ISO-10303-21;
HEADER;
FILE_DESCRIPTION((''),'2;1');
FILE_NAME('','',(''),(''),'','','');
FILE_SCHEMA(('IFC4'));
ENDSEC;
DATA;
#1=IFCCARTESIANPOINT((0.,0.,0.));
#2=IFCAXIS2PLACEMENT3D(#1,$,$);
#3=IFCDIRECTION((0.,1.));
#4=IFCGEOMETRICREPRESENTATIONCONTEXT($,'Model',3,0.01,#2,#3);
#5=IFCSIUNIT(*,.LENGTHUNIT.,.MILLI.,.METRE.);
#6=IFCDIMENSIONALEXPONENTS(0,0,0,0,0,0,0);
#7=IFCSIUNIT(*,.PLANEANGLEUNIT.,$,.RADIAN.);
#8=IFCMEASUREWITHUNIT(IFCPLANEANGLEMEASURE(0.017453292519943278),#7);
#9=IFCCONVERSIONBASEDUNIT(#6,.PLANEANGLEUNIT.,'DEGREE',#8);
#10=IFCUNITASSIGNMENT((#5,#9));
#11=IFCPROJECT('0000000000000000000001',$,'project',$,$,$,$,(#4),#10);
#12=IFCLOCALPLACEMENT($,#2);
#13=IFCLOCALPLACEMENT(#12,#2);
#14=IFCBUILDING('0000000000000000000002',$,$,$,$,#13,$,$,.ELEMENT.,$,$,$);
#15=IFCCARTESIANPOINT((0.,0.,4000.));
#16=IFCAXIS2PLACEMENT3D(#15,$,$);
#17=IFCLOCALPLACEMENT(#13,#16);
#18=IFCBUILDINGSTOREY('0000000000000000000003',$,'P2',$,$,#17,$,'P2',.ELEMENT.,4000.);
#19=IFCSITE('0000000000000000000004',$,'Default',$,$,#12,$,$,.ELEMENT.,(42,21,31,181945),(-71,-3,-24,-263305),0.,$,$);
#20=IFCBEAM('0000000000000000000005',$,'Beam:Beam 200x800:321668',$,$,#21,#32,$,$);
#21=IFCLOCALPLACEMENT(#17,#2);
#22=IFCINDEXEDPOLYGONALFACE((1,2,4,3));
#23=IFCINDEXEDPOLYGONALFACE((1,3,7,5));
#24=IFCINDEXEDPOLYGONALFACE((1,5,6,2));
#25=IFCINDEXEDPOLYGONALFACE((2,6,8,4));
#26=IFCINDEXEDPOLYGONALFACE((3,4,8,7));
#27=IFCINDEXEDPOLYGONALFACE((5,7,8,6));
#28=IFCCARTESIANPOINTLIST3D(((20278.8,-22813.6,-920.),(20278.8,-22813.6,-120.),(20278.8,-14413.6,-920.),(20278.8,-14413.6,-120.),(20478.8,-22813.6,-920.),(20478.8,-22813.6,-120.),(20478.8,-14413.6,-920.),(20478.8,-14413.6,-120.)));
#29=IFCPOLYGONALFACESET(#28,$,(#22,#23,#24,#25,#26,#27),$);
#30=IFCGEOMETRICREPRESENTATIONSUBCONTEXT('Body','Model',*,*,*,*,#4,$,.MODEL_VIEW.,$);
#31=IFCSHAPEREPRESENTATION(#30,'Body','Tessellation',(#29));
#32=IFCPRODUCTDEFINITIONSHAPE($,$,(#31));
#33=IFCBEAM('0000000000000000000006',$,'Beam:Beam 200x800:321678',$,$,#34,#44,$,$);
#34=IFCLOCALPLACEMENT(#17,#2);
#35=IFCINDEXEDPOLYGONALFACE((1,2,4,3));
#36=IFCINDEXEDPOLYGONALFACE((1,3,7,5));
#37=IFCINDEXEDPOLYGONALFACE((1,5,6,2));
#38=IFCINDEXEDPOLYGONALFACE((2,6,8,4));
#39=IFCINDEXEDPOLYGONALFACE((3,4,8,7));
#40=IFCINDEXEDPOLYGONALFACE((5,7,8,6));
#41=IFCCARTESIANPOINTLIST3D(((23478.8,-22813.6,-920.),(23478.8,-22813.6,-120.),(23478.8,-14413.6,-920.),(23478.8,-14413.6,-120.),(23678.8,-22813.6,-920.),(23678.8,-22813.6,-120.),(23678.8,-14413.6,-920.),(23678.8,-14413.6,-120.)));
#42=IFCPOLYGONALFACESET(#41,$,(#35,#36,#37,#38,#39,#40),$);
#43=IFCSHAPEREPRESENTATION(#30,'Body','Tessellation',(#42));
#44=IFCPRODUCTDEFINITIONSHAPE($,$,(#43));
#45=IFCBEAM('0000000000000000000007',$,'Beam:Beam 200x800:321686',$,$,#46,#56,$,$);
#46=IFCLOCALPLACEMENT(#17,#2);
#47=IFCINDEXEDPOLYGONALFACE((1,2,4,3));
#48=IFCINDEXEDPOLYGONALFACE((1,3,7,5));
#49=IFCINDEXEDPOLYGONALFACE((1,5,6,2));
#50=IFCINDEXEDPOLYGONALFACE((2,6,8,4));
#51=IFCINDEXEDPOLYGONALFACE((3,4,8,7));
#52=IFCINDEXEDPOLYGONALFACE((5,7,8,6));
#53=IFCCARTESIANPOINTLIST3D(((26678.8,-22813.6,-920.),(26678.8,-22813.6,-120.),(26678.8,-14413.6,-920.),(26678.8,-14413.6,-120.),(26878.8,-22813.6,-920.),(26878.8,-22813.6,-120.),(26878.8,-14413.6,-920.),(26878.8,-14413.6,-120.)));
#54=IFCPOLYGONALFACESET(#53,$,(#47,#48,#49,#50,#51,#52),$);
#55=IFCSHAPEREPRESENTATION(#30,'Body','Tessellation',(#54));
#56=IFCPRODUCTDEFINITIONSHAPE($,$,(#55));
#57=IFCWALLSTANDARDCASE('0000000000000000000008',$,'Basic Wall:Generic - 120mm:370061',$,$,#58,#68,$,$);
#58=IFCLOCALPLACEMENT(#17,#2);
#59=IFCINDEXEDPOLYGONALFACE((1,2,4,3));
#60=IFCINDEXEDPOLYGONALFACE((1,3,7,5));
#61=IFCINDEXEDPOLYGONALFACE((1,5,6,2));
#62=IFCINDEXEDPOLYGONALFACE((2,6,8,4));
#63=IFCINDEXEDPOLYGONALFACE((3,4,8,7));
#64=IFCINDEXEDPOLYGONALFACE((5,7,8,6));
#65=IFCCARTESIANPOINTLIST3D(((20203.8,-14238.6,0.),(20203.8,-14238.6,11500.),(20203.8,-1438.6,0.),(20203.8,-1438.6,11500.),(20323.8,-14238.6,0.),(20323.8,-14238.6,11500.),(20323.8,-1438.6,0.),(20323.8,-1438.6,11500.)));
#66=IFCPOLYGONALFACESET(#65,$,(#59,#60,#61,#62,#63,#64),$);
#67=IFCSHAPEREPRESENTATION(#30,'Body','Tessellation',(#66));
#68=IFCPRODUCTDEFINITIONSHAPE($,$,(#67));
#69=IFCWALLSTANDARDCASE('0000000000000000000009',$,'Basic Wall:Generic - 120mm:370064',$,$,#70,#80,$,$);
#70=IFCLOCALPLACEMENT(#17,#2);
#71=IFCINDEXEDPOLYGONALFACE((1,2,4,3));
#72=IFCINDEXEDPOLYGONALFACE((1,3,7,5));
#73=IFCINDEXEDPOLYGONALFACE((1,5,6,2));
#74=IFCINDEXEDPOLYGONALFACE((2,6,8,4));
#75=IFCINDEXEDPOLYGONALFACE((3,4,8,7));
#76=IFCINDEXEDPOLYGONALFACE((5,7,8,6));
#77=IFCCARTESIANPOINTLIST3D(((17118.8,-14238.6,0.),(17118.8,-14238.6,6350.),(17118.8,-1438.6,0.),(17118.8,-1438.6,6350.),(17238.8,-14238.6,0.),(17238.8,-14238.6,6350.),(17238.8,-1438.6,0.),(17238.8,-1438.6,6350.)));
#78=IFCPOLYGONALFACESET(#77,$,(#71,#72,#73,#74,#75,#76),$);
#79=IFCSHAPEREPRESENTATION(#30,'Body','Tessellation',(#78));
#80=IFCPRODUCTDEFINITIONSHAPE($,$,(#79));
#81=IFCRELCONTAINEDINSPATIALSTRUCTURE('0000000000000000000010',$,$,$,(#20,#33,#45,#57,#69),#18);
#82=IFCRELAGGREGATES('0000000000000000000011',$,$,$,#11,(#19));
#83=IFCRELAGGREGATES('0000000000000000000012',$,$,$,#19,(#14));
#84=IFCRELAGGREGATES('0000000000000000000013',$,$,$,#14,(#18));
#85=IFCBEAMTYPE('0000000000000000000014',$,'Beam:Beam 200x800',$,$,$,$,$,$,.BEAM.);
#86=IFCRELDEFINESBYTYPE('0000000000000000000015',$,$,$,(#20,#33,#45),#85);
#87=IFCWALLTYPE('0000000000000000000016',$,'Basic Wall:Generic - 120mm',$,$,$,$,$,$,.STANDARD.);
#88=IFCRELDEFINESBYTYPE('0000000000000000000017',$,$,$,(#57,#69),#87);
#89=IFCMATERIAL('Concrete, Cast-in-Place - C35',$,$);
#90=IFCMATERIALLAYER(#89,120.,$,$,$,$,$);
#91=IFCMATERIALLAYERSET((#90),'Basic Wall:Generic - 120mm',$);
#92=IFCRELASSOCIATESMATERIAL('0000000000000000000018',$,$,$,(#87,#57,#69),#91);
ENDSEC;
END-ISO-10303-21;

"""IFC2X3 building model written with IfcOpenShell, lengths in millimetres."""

from ifc_helpers import new_model, entity, si_unit, converted_unit, direction, frame, frame_2d, origin, place, context, subcontext, project, spatial, rectangle, extrude, material, layer, layer_set, layer_usage, type_object, element, save


model = new_model("IFC2X3")

# Units and contexts
model_context = context("Model", 3, precision=0.01, world=origin(), true_north=direction((0.0, 1.0)))
body_context = subcontext(model_context, "Body", "Model", "MODEL_VIEW")
ifc_project = project(units=[si_unit("LENGTHUNIT", "METRE", prefix="MILLI"), converted_unit("PLANEANGLEUNIT", "DEGREE", entity("IfcPlaneAngleMeasure", 0.017453292519943278), si_unit("PLANEANGLEUNIT", "RADIAN"), dimensions=[0, 0, 0, 0, 0, 0, 0])], contexts=[model_context])

# Site, building, storey
site_placement = place(None, origin())
site = spatial("IfcSite", under=ifc_project, at=site_placement, Name="Default", CompositionType="ELEMENT", RefLatitude=(42, 21, 31, 181945), RefLongitude=(-71, -3, -24, -263305), RefElevation=0.0)
building_placement = place(site_placement, origin())
building = spatial("IfcBuilding", under=site, at=building_placement, CompositionType="ELEMENT")
storey_placement = place(building_placement, frame((0.0, 0.0, 4000.0)))
storey = spatial("IfcBuildingStorey", under=building, at=storey_placement, Name="P2", LongName="P2", CompositionType="ELEMENT", Elevation=4000.0)

# Shared definitions
ifc_material = material(Name="Concrete, Cast-in-Place - C35")

# Beams
beam_type_1 = type_object("IfcBeamType", Name="Beam:Beam 200x800", PredefinedType="BEAM")
for number, where, z_axis, x_axis, name in (
    (1, (20353.8, -14413.6, -120.0), (0.0, 0.0, 1.0), (0.0, -1.0, 0.0), "Beam:Beam 200x800:321668"),
    (2, (23553.8, -14413.6, -120.0), (0.0, 0.0, 1.0), (0.0, -1.0, 0.0), "Beam:Beam 200x800:321678"),
):
    element("IfcBeam", number, at=place(storey_placement, frame(where, z_axis=z_axis, x_axis=x_axis)), inside=storey, type_object=beam_type_1, Name=name, context=body_context, shape_type="SweptSolid", body=[
        extrude(rectangle(XDim=800.0, YDim=200.0, at=frame_2d((0.0, 0.0), x_axis=(1.0, 0.0))), frame((0.0, 25.0, -400.0), z_axis=(1.0, 0.0, 0.0), x_axis=(0.0, 0.0, -1.0)), (0.0, 0.0, 1.0), 8400.0),
    ])
beam_1_placement = place(storey_placement, frame((26753.8, -14413.6, -120.0), z_axis=(0.0, 0.0, 1.0), x_axis=(0.0, -1.0, 0.0)))
element("IfcBeam", 3, at=beam_1_placement, inside=storey, type_object=beam_type_1, Name="Beam:Beam 200x800:321686", context=body_context, shape_type="SweptSolid", body=[
    extrude(rectangle(XDim=800.0, YDim=200.0, at=frame_2d((0.0, 0.0), x_axis=(1.0, 0.0))), frame((0.0, 25.0, -400.0), z_axis=(1.0, 0.0, 0.0), x_axis=(0.0, 0.0, -1.0)), (0.0, 0.0, 1.0), 8400.0),
])

# Walls
ifc_layer = layer(ifc_material, 120.0)
ifc_layer_set = layer_set([ifc_layer], Name="Basic Wall:Generic - 120mm")
ifc_layer_usage_1 = layer_usage(ifc_layer_set, "AXIS2", "NEGATIVE", 60.0)
wall_type = type_object("IfcWallType", Name="Basic Wall:Generic - 120mm", PredefinedType="STANDARD", material=ifc_layer_set)
wall_1_placement = place(storey_placement, frame((20263.8, -1438.6, 0.0), z_axis=(0.0, 0.0, 1.0), x_axis=(0.0, -1.0, 0.0)))
element("IfcWallStandardCase", 4, at=wall_1_placement, inside=storey, type_object=wall_type, material=ifc_layer_usage_1, Name="Basic Wall:Generic - 120mm:370061", context=body_context, shape_type="SweptSolid", body=[
    extrude(rectangle(XDim=12800.0, YDim=120.0, at=frame_2d((6400.0, 0.0), x_axis=(-1.0, 0.0))), origin(), (0.0, 0.0, 1.0), 11500.0),
])
ifc_layer_usage_2 = layer_usage(ifc_layer_set, "AXIS2", "NEGATIVE", 60.0)
wall_2_placement = place(storey_placement, frame((17178.8, -1438.6, 0.0), z_axis=(0.0, 0.0, 1.0), x_axis=(0.0, -1.0, 0.0)))
element("IfcWallStandardCase", 5, at=wall_2_placement, inside=storey, type_object=wall_type, material=ifc_layer_usage_2, Name="Basic Wall:Generic - 120mm:370064", context=body_context, shape_type="SweptSolid", body=[
    extrude(rectangle(XDim=12800.0, YDim=120.0, at=frame_2d((6400.0, 0.0), x_axis=(-1.0, 0.0))), origin(), (0.0, 0.0, 1.0), 6350.0),
])

save(model, "model.ifc")
